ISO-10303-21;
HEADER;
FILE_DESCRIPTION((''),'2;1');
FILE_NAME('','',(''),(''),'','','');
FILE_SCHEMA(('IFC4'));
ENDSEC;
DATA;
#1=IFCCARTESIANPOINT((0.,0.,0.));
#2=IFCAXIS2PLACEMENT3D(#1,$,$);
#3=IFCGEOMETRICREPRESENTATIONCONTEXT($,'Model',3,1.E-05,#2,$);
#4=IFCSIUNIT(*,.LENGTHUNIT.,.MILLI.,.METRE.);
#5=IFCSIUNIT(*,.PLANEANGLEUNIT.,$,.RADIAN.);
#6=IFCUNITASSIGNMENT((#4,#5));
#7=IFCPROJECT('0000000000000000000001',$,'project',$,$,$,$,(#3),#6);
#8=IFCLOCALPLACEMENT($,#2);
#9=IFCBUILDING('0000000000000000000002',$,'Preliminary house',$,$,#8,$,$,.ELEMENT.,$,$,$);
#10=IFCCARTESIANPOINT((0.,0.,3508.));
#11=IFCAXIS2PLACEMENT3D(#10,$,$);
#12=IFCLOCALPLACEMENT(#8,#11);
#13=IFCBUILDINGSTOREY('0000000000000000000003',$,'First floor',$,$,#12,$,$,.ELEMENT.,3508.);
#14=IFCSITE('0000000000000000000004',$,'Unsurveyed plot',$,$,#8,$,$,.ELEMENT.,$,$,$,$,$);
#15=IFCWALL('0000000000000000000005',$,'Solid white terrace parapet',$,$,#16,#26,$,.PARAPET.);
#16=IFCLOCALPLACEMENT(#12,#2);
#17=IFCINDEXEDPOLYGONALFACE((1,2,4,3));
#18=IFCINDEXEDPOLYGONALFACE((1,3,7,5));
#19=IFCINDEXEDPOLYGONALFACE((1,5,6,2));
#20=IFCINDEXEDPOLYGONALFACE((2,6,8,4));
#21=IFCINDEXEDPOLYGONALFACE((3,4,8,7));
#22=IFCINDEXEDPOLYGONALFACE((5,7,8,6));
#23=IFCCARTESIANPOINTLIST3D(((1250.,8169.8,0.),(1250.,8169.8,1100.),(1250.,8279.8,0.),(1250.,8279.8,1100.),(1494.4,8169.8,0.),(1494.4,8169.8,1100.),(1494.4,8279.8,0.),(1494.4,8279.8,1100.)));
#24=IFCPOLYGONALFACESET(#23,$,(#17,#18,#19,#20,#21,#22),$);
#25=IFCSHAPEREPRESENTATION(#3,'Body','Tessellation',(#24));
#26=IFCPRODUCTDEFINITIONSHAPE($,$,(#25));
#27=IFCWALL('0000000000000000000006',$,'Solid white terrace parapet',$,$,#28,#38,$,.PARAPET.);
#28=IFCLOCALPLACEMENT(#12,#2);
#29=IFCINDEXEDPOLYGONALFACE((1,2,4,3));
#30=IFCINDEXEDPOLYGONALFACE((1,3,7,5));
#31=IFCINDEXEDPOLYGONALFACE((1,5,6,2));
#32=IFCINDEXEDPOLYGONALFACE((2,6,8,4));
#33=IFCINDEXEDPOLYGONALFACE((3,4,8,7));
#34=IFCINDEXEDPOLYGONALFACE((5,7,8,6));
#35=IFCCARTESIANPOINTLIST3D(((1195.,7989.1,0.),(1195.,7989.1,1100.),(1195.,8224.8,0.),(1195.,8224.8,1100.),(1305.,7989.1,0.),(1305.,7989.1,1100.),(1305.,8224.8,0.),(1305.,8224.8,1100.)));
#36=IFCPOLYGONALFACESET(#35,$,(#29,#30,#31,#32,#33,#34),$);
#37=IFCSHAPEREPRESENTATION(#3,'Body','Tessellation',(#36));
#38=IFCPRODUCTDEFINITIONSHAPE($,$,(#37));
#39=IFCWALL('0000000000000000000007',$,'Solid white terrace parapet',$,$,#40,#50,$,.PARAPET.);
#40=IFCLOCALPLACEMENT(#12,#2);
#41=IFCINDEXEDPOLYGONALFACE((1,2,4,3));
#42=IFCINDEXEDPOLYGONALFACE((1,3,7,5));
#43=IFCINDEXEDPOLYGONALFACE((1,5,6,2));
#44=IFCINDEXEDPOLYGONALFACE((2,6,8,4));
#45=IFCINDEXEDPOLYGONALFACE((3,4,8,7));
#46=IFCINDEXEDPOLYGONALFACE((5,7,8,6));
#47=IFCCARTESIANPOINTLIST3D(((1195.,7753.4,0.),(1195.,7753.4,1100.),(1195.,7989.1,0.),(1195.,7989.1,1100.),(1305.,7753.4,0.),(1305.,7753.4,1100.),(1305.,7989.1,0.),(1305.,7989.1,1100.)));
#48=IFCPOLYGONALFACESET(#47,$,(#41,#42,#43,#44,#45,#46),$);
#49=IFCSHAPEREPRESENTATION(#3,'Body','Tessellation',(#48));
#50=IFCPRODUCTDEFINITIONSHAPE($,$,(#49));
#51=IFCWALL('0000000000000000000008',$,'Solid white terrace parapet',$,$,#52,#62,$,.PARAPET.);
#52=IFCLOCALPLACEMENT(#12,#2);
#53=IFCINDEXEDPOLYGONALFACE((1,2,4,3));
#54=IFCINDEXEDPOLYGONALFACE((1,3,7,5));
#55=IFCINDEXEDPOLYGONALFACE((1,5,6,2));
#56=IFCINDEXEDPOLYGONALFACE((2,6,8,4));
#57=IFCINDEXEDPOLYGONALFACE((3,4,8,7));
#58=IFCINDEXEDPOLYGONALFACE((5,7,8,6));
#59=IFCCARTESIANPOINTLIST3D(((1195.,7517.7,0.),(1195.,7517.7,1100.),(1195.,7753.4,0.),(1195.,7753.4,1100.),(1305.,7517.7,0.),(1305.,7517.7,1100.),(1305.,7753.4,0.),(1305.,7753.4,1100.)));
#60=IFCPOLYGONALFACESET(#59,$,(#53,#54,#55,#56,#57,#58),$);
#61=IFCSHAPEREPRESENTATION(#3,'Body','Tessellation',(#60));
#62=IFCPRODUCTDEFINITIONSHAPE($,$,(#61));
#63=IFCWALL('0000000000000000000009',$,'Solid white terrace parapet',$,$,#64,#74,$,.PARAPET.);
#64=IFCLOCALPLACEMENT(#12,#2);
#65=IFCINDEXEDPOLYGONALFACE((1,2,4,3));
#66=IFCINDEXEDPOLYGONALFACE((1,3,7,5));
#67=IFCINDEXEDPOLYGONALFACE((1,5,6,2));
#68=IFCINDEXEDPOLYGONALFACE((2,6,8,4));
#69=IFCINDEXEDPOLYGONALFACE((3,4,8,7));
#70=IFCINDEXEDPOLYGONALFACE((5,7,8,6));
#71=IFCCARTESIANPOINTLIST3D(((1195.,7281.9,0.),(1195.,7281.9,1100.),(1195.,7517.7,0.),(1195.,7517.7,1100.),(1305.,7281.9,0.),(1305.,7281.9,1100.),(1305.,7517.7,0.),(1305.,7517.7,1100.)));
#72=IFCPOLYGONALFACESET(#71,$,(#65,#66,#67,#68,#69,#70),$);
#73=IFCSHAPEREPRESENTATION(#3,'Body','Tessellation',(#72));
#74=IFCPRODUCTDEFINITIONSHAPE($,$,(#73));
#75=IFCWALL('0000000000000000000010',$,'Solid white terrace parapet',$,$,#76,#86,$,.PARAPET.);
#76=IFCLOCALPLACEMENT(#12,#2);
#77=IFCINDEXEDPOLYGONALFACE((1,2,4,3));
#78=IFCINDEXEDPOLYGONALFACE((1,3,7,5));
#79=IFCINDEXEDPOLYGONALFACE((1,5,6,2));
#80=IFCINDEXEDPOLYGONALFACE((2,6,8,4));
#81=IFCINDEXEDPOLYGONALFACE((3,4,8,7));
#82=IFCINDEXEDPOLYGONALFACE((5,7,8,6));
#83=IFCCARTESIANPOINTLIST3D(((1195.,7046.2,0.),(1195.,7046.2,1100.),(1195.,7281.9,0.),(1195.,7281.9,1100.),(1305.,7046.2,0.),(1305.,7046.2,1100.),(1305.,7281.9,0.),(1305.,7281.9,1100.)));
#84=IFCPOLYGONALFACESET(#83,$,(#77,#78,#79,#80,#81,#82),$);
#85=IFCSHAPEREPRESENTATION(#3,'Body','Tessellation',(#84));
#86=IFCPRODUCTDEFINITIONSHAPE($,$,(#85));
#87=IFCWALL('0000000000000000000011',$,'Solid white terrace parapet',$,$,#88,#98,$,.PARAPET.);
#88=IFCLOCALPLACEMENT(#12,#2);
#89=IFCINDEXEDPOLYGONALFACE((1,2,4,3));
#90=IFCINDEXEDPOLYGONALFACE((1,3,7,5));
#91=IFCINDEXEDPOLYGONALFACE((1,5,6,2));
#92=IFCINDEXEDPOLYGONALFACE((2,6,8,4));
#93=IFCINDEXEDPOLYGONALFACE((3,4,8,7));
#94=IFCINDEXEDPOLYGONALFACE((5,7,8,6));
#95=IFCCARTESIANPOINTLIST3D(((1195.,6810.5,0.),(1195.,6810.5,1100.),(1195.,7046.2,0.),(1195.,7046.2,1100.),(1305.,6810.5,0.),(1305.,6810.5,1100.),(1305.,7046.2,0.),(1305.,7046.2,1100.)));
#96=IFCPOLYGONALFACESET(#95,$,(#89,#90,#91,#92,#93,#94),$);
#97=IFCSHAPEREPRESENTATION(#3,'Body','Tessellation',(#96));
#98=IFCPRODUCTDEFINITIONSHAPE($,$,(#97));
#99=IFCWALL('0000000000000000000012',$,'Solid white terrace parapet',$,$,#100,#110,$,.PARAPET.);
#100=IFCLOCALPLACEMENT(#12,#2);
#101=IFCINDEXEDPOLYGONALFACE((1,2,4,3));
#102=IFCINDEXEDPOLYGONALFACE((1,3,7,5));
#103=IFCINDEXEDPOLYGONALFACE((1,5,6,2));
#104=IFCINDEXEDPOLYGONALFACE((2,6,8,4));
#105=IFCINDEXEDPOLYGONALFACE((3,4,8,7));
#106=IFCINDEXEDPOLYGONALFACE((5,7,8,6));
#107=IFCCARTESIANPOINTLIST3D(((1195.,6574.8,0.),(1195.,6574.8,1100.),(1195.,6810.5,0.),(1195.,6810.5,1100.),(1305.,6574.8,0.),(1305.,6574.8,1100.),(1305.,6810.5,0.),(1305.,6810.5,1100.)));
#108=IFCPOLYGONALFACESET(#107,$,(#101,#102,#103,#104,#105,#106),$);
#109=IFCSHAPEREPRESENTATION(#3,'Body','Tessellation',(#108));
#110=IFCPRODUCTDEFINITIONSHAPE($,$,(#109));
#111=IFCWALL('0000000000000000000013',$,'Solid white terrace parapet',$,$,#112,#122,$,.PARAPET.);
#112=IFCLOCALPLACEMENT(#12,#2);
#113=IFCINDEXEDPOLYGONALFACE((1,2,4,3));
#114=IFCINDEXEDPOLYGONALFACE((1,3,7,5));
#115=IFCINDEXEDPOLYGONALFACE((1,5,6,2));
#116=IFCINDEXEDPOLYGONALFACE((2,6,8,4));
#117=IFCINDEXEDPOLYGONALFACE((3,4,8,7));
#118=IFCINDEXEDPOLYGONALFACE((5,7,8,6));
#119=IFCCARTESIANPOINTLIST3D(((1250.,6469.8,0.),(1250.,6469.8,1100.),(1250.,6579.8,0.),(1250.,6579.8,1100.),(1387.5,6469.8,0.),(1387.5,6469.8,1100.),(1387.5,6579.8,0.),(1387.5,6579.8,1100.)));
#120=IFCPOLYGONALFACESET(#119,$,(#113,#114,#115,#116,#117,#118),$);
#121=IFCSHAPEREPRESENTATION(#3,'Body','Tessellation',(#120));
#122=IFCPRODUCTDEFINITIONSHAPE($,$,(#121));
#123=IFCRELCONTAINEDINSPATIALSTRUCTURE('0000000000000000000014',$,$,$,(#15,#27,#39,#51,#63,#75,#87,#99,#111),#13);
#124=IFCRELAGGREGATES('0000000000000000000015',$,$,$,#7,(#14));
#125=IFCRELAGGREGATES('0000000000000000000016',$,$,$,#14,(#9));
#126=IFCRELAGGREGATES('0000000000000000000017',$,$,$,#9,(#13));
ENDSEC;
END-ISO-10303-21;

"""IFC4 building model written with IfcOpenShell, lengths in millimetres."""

from ifc_helpers import new_model, si_unit, frame, origin, place, context, project, spatial, polyline, outline, extrude, element, save


model = new_model("IFC4")

# Units and contexts
model_context = context("Model", 3, precision=1e-05, world=origin())
ifc_project = project(units=[si_unit("LENGTHUNIT", "METRE", prefix="MILLI"), si_unit("PLANEANGLEUNIT", "RADIAN")], contexts=[model_context])

# Site, building, storey
placement_1 = place(None, origin())
site = spatial("IfcSite", under=ifc_project, at=placement_1, Name="Unsurveyed plot", CompositionType="ELEMENT")
building = spatial("IfcBuilding", under=site, at=placement_1, Name="Preliminary house", CompositionType="ELEMENT")
placement_2 = place(placement_1, frame((0.0, 0.0, 3508.0)))
storey = spatial("IfcBuildingStorey", under=building, at=placement_2, Name="First floor", CompositionType="ELEMENT", Elevation=3508.0)

# Walls
element("IfcWall", 1, at=placement_2, inside=storey, Name="Solid white terrace parapet", PredefinedType="PARAPET", context=model_context, shape_type="SweptSolid", body=[
    extrude(outline(polyline([(1250.0, 8169.8), (1250.0, 8279.8), (1494.4, 8279.8), (1494.4, 8169.8), (1250.0, 8169.8)])), origin(), (0.0, 0.0, 1.0), 1100.0),
])
element("IfcWall", 2, at=placement_2, inside=storey, Name="Solid white terrace parapet", PredefinedType="PARAPET", context=model_context, shape_type="SweptSolid", body=[
    extrude(outline(polyline([(1305.0, 7989.1), (1195.0, 7989.1), (1195.0, 8224.8), (1305.0, 8224.8), (1305.0, 7989.1)])), origin(), (0.0, 0.0, 1.0), 1100.0),
])
element("IfcWall", 3, at=placement_2, inside=storey, Name="Solid white terrace parapet", PredefinedType="PARAPET", context=model_context, shape_type="SweptSolid", body=[
    extrude(outline(polyline([(1305.0, 7753.4), (1195.0, 7753.4), (1195.0, 7989.1), (1305.0, 7989.1), (1305.0, 7753.4)])), origin(), (0.0, 0.0, 1.0), 1100.0),
])
element("IfcWall", 4, at=placement_2, inside=storey, Name="Solid white terrace parapet", PredefinedType="PARAPET", context=model_context, shape_type="SweptSolid", body=[
    extrude(outline(polyline([(1305.0, 7517.7), (1195.0, 7517.7), (1195.0, 7753.4), (1305.0, 7753.4), (1305.0, 7517.7)])), origin(), (0.0, 0.0, 1.0), 1100.0),
])
element("IfcWall", 5, at=placement_2, inside=storey, Name="Solid white terrace parapet", PredefinedType="PARAPET", context=model_context, shape_type="SweptSolid", body=[
    extrude(outline(polyline([(1305.0, 7281.9), (1195.0, 7281.9), (1195.0, 7517.7), (1305.0, 7517.7), (1305.0, 7281.9)])), origin(), (0.0, 0.0, 1.0), 1100.0),
])
element("IfcWall", 6, at=placement_2, inside=storey, Name="Solid white terrace parapet", PredefinedType="PARAPET", context=model_context, shape_type="SweptSolid", body=[
    extrude(outline(polyline([(1305.0, 7046.2), (1195.0, 7046.2), (1195.0, 7281.9), (1305.0, 7281.9), (1305.0, 7046.2)])), origin(), (0.0, 0.0, 1.0), 1100.0),
])
element("IfcWall", 7, at=placement_2, inside=storey, Name="Solid white terrace parapet", PredefinedType="PARAPET", context=model_context, shape_type="SweptSolid", body=[
    extrude(outline(polyline([(1305.0, 6810.5), (1195.0, 6810.5), (1195.0, 7046.2), (1305.0, 7046.2), (1305.0, 6810.5)])), origin(), (0.0, 0.0, 1.0), 1100.0),
])
element("IfcWall", 8, at=placement_2, inside=storey, Name="Solid white terrace parapet", PredefinedType="PARAPET", context=model_context, shape_type="SweptSolid", body=[
    extrude(outline(polyline([(1305.0, 6574.8), (1195.0, 6574.8), (1195.0, 6810.5), (1305.0, 6810.5), (1305.0, 6574.8)])), origin(), (0.0, 0.0, 1.0), 1100.0),
])
element("IfcWall", 9, at=placement_2, inside=storey, Name="Solid white terrace parapet", PredefinedType="PARAPET", context=model_context, shape_type="SweptSolid", body=[
    extrude(outline(polyline([(1387.5, 6579.8), (1387.5, 6469.8), (1250.0, 6469.8), (1250.0, 6579.8), (1387.5, 6579.8)])), origin(), (0.0, 0.0, 1.0), 1100.0),
])

save(model, "model.ifc")
